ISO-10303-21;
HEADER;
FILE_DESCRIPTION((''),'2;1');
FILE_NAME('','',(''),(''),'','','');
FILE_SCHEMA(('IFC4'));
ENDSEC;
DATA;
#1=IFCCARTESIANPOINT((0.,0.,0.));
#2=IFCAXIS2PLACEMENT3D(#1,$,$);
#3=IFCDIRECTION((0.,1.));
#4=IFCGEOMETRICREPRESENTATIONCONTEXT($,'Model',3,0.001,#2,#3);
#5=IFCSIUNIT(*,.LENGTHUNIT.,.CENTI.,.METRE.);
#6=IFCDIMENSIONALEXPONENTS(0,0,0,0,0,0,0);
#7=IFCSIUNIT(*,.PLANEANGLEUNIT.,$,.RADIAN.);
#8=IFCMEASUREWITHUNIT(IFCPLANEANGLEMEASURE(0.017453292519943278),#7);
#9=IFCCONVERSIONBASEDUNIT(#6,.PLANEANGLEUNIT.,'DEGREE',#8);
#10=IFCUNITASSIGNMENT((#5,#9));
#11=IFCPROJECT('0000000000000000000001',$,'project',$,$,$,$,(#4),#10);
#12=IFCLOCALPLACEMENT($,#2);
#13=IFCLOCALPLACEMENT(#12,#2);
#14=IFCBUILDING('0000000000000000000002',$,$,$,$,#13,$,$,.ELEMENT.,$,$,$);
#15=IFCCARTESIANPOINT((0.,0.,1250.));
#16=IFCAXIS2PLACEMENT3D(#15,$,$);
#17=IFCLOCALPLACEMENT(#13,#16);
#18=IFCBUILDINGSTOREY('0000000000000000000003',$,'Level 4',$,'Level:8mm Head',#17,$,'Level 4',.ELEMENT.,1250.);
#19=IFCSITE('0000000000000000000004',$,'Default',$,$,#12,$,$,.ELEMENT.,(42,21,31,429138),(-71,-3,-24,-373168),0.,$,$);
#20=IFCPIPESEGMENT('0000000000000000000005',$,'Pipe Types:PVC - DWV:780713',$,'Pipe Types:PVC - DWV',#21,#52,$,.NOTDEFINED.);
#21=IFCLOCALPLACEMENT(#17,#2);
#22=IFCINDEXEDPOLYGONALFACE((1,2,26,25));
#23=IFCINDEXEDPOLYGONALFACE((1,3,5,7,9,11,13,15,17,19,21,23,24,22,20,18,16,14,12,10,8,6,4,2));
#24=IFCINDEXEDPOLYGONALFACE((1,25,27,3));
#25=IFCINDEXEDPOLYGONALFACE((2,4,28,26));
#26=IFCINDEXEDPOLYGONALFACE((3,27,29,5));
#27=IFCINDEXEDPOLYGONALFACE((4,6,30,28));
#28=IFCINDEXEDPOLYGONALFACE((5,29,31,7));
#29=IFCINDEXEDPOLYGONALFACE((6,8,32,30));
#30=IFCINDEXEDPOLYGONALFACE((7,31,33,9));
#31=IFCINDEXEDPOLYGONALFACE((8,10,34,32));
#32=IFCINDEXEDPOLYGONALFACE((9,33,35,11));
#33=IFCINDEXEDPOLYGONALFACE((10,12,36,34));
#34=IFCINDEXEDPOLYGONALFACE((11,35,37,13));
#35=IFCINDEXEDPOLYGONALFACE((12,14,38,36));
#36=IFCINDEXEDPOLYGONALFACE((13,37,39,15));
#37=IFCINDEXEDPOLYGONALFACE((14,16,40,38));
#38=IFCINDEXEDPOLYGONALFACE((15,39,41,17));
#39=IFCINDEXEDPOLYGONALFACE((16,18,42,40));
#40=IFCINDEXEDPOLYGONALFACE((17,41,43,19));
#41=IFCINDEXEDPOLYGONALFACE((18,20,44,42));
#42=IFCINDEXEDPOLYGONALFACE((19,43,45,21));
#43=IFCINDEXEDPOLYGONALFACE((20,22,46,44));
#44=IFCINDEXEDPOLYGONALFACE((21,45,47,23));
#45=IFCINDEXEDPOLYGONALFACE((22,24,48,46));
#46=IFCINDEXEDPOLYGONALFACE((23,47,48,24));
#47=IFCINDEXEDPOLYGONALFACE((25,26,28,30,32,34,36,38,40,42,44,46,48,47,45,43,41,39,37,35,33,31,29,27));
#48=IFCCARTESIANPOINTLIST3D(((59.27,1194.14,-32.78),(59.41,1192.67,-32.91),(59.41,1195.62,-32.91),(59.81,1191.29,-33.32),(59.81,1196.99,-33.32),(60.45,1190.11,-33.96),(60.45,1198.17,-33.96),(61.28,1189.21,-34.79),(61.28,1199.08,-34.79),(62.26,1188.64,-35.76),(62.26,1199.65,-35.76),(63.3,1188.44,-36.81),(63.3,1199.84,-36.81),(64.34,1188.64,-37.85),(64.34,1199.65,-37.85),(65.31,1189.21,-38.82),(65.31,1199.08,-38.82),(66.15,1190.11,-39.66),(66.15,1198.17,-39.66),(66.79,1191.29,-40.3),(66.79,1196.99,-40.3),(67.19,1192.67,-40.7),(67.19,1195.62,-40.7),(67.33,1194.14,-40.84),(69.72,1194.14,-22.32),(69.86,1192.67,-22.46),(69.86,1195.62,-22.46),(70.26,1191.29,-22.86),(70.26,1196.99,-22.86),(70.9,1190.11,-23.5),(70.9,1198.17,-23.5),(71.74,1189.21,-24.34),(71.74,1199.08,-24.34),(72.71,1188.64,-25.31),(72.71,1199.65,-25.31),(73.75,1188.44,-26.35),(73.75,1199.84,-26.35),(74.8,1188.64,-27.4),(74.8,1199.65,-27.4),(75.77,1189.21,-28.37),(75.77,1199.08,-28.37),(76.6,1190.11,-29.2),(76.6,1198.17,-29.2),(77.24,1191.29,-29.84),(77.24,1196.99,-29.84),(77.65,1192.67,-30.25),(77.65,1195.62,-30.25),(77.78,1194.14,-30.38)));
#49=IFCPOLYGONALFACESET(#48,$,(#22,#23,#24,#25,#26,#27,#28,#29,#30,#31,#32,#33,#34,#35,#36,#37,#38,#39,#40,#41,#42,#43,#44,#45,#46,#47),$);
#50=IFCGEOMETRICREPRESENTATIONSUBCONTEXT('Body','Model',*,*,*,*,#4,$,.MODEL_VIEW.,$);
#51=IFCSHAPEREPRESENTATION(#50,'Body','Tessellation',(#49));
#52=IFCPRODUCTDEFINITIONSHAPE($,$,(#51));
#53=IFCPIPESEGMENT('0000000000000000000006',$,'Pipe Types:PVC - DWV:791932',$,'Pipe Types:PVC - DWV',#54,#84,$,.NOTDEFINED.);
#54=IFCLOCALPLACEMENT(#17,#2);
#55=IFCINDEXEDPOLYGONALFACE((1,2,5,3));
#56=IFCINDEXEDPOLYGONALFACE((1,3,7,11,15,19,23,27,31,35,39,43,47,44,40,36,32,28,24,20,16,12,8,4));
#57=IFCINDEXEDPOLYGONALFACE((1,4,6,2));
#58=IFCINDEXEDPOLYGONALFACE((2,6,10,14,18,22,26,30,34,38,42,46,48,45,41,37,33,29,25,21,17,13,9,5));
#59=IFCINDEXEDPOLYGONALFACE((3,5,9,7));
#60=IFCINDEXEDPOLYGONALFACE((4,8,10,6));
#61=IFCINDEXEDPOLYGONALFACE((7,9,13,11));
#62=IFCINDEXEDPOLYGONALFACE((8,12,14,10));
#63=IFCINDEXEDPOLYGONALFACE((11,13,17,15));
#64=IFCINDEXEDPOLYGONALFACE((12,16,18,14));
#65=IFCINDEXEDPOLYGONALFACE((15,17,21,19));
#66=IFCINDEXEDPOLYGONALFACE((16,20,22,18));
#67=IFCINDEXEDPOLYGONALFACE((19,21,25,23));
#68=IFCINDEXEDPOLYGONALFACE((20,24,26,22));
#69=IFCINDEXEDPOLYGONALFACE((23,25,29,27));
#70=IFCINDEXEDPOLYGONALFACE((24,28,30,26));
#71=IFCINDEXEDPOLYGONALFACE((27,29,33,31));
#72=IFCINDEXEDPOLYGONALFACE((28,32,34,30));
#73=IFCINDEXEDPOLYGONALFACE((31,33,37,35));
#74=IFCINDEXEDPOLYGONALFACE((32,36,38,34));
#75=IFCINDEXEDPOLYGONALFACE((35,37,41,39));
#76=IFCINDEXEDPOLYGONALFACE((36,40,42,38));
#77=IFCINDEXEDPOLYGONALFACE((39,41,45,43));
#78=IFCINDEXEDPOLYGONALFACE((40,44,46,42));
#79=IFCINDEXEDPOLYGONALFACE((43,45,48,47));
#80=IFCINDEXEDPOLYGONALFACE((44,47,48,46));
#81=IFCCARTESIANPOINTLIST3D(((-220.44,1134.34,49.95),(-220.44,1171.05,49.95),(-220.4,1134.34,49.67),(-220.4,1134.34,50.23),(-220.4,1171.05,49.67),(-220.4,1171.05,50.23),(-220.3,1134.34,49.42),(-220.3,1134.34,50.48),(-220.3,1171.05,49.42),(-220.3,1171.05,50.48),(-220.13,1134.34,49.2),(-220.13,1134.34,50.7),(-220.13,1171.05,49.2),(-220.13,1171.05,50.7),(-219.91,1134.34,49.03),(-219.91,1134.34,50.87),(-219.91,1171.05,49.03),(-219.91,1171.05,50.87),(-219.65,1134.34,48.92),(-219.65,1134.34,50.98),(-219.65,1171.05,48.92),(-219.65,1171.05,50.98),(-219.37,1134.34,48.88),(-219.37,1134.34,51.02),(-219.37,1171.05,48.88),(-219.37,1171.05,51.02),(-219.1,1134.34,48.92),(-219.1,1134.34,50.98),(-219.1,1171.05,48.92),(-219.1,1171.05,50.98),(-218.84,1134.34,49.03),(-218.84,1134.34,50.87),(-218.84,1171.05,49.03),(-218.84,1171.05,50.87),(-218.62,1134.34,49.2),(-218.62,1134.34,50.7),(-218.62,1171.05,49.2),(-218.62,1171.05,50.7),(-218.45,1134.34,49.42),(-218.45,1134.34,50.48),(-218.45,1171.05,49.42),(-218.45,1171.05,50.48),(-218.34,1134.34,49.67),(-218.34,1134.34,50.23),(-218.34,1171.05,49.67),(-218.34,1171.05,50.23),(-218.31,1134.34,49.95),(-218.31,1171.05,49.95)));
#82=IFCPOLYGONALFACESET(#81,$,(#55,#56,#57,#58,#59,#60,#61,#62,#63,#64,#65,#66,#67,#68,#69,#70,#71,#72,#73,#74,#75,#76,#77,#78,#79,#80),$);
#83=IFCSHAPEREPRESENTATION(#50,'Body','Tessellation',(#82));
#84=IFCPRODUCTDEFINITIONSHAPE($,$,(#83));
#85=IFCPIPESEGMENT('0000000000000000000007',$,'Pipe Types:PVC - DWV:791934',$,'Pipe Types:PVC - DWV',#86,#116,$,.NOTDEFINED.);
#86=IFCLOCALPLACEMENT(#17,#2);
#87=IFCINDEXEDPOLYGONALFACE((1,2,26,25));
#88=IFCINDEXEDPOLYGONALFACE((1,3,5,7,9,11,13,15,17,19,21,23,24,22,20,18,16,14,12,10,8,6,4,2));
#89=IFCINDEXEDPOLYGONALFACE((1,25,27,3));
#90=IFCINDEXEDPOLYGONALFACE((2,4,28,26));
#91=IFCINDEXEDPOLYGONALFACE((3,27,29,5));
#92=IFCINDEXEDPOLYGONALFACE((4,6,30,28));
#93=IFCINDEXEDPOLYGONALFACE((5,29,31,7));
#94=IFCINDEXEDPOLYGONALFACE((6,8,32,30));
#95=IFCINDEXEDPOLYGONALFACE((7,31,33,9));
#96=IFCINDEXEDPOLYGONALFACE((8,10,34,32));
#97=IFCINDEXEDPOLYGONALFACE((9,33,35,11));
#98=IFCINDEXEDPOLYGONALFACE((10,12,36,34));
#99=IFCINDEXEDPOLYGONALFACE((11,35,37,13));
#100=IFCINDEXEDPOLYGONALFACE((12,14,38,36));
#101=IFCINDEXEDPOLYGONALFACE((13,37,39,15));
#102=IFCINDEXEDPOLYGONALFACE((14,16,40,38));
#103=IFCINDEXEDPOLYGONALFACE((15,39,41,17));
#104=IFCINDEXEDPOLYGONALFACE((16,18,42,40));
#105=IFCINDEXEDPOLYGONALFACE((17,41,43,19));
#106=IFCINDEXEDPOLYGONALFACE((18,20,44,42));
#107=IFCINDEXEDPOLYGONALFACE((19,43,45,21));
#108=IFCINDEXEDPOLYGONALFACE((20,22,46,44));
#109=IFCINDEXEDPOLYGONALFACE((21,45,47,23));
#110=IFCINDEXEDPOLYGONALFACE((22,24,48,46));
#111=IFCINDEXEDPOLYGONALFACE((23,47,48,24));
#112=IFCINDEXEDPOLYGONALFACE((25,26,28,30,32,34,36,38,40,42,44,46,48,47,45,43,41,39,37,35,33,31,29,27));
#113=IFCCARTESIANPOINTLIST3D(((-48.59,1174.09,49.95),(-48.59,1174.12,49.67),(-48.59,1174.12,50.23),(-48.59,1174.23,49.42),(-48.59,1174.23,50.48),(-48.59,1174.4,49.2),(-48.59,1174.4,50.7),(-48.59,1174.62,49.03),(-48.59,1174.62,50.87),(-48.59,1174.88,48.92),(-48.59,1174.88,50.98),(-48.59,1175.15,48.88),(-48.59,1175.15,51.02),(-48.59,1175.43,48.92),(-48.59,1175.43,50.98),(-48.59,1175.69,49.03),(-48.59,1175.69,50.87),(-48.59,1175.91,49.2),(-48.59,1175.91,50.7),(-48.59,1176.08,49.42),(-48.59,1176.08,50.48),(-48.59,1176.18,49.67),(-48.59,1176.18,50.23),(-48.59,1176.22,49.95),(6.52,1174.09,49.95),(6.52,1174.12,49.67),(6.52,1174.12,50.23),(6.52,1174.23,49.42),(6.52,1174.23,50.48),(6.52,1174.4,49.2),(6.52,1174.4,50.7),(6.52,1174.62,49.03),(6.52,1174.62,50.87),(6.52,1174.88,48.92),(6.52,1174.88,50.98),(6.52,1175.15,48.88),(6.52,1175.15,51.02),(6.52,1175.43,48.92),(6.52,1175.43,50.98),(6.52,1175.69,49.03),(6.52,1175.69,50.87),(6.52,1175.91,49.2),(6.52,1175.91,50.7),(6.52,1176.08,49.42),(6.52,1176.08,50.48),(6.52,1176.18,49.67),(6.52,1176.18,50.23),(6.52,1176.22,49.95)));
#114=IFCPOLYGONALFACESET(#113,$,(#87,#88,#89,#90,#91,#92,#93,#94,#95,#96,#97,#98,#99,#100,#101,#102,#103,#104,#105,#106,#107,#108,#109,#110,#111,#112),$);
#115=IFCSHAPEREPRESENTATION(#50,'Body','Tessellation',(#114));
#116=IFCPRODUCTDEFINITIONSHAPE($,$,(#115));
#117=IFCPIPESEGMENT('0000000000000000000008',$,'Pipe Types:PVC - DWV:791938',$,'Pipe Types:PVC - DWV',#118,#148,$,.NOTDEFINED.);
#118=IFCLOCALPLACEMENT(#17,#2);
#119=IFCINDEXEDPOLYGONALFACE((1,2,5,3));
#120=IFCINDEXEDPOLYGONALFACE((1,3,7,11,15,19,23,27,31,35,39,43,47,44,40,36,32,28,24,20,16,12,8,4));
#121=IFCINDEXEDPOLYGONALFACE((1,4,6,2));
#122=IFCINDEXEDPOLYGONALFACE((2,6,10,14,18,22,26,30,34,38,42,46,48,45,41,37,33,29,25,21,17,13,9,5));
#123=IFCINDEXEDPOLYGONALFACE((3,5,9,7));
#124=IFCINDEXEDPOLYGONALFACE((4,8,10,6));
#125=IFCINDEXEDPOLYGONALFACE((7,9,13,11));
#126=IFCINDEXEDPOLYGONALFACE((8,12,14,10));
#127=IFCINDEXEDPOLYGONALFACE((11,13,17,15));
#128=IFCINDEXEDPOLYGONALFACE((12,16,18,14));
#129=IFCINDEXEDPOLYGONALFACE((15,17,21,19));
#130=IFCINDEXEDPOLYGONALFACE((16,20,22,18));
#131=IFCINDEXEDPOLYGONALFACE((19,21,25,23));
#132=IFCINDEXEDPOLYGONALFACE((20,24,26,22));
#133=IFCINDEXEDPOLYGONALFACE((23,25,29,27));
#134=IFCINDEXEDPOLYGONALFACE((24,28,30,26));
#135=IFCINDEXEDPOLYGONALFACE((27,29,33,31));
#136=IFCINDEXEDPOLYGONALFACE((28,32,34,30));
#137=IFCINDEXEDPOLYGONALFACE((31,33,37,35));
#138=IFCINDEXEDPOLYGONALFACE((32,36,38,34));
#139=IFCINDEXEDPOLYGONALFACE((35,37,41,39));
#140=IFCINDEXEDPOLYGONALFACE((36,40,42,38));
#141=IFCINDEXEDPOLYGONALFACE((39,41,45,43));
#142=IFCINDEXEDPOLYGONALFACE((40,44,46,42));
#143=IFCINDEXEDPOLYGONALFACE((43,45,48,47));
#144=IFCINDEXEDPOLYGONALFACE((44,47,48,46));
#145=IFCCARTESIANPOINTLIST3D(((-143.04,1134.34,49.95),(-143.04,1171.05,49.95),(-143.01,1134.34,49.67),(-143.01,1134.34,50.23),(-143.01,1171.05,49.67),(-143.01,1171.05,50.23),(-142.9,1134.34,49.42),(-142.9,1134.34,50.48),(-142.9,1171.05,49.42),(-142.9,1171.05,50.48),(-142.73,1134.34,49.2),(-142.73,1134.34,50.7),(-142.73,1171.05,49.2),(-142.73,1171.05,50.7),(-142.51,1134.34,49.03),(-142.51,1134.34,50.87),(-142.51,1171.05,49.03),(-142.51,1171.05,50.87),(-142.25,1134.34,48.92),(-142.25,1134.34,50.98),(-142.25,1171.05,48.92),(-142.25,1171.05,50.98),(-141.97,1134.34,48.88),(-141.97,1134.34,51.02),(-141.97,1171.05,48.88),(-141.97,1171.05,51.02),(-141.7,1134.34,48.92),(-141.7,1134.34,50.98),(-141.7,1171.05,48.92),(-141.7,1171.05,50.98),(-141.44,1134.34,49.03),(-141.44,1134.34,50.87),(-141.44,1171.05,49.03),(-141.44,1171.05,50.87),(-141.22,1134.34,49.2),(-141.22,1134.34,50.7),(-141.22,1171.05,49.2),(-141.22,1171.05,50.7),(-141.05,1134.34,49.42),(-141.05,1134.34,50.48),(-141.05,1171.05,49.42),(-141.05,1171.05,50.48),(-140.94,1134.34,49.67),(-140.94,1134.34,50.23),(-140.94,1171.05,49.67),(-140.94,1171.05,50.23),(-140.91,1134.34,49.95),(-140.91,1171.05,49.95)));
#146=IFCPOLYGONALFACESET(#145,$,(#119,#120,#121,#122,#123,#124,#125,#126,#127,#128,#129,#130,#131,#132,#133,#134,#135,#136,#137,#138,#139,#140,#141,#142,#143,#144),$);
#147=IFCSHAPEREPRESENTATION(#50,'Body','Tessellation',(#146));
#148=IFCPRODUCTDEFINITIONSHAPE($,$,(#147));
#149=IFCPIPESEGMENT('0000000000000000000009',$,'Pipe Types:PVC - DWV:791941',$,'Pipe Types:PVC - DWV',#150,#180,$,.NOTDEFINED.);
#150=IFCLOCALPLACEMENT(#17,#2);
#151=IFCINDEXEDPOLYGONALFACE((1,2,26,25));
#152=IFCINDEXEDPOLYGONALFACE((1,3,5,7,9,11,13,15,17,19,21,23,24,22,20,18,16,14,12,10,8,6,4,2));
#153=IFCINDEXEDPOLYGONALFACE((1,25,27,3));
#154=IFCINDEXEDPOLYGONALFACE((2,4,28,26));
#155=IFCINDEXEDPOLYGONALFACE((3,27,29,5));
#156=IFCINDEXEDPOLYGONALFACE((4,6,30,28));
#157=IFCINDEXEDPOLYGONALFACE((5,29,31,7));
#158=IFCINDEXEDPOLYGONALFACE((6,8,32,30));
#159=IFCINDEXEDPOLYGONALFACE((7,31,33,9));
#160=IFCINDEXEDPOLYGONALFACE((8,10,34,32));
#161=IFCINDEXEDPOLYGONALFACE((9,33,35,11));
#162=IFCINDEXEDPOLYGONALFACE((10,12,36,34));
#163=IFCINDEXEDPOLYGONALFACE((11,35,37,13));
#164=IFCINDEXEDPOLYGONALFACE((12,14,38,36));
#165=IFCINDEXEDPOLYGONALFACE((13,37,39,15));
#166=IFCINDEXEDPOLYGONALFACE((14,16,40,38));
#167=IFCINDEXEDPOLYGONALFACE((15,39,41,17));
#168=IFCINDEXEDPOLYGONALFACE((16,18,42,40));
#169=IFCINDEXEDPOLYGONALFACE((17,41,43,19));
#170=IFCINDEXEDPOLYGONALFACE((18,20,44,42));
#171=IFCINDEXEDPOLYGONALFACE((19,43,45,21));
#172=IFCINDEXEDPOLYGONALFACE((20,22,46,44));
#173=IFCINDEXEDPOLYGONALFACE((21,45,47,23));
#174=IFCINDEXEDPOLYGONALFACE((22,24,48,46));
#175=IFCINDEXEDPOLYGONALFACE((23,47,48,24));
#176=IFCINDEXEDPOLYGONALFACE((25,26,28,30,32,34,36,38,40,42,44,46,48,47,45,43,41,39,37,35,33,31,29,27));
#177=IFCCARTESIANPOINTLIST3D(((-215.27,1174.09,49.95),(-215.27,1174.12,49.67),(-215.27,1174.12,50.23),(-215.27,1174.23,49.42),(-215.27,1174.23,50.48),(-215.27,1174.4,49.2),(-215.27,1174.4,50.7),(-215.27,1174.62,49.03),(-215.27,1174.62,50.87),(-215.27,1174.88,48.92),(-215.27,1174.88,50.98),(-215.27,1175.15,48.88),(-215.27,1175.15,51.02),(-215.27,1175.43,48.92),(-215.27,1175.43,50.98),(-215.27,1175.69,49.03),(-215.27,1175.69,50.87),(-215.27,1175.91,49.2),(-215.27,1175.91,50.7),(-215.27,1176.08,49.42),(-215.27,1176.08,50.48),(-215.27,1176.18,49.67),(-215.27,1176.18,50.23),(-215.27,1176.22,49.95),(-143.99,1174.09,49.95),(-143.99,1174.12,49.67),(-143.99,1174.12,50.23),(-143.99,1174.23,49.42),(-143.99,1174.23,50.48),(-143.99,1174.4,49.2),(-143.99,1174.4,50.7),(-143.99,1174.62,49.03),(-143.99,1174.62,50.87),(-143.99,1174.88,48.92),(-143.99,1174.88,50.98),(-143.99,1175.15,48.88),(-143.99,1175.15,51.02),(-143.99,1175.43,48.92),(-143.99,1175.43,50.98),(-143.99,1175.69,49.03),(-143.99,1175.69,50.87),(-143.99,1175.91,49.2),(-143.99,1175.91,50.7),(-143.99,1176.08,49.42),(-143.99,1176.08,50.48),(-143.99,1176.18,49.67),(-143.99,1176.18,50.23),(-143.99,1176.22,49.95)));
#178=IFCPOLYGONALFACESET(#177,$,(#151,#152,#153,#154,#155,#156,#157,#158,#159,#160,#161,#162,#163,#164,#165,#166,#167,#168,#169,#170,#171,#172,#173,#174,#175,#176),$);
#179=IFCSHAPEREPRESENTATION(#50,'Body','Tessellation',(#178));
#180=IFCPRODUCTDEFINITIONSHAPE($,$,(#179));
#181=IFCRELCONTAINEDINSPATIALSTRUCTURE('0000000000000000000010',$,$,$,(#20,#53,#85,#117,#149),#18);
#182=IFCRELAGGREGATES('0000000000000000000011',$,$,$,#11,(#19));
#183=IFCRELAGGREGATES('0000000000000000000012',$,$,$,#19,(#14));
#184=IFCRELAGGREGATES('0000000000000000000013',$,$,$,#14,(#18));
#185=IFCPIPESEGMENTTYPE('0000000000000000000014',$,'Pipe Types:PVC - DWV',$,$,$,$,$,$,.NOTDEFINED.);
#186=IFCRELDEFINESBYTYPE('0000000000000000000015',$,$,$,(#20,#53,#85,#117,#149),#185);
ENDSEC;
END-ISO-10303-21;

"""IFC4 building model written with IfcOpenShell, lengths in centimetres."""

from ifc_helpers import new_model, entity, si_unit, converted_unit, direction, frame, origin, place, context, subcontext, project, spatial, arc, indexed_curve, outline, extrude, type_object, element, save


model = new_model("IFC4")

# Units and contexts
model_context = context("Model", 3, precision=0.001, world=origin(), true_north=direction((0.0, 1.0)))
body_context = subcontext(model_context, "Body", "Model", "MODEL_VIEW")
ifc_project = project(units=[si_unit("LENGTHUNIT", "METRE", prefix="CENTI"), converted_unit("PLANEANGLEUNIT", "DEGREE", entity("IfcPlaneAngleMeasure", 0.017453292519943278), si_unit("PLANEANGLEUNIT", "RADIAN"), dimensions=[0, 0, 0, 0, 0, 0, 0])], contexts=[model_context])

# Site, building, storey
site_placement = place(None, origin())
site = spatial("IfcSite", under=ifc_project, at=site_placement, Name="Default", CompositionType="ELEMENT", RefLatitude=(42, 21, 31, 429138), RefLongitude=(-71, -3, -24, -373168), RefElevation=0.0)
building_placement = place(site_placement, origin())
building = spatial("IfcBuilding", under=site, at=building_placement, CompositionType="ELEMENT")
storey_placement = place(building_placement, frame((0.0, 0.0, 1250.0)))
storey = spatial("IfcBuildingStorey", under=building, at=storey_placement, Name="Level 4", ObjectType="Level:8mm Head", LongName="Level 4", CompositionType="ELEMENT", Elevation=1250.0)

# Pipe segments
pipe_segment_type = type_object("IfcPipeSegmentType", Name="Pipe Types:PVC - DWV", PredefinedType="NOTDEFINED")
pipe_segment_1_placement = place(storey_placement, origin())
element("IfcPipeSegment", 1, at=pipe_segment_1_placement, inside=storey, type_object=pipe_segment_type, Name="Pipe Types:PVC - DWV:780713", ObjectType="Pipe Types:PVC - DWV", PredefinedType="NOTDEFINED", context=body_context, shape_type="SweptSolid", body=[
    extrude(outline(indexed_curve([(5.7, 0.0), (4.03, 4.03), (0.0, 5.7), (-4.03, 4.03), (-5.7, 0.0), (-4.03, -4.03), (0.0, -5.7), (4.03, -4.03)], segments=[arc(1, 2, 3), arc(3, 4, 5), arc(5, 6, 7), arc(7, 8, 1)], self_intersect=False)), frame((63.3, 1194.14, -36.81), z_axis=(0.707107, 0.0, 0.707107), x_axis=(0.0, -1.0, 0.0)), (0.0, 0.0, 1.0), 14.78),
])
pipe_segment_2_placement = place(storey_placement, origin())
element("IfcPipeSegment", 2, at=pipe_segment_2_placement, inside=storey, type_object=pipe_segment_type, Name="Pipe Types:PVC - DWV:791932", ObjectType="Pipe Types:PVC - DWV", PredefinedType="NOTDEFINED", context=body_context, shape_type="SweptSolid", body=[
    extrude(outline(indexed_curve([(1.07, 0.0), (0.75, 0.75), (0.0, 1.07), (-0.75, 0.75), (-1.07, 0.0), (-0.75, -0.75), (0.0, -1.07), (0.75, -0.75)], segments=[arc(1, 2, 3), arc(3, 4, 5), arc(5, 6, 7), arc(7, 8, 1)], self_intersect=False)), frame((-219.37, 1134.34, 49.95), z_axis=(0.0, 1.0, 0.0), x_axis=(1.0, 0.0, 0.0)), (0.0, 0.0, 1.0), 36.71),
])
pipe_segment_3_placement = place(storey_placement, origin())
element("IfcPipeSegment", 3, at=pipe_segment_3_placement, inside=storey, type_object=pipe_segment_type, Name="Pipe Types:PVC - DWV:791934", ObjectType="Pipe Types:PVC - DWV", PredefinedType="NOTDEFINED", context=body_context, shape_type="SweptSolid", body=[
    extrude(outline(indexed_curve([(1.07, 0.0), (0.75, 0.75), (0.0, 1.07), (-0.75, 0.75), (-1.07, 0.0), (-0.75, -0.75), (0.0, -1.07), (0.75, -0.75)], segments=[arc(1, 2, 3), arc(3, 4, 5), arc(5, 6, 7), arc(7, 8, 1)], self_intersect=False)), frame((-48.59, 1175.15, 49.95), z_axis=(1.0, 0.0, 0.0), x_axis=(0.0, -1.0, 0.0)), (0.0, 0.0, 1.0), 55.11),
])
pipe_segment_4_placement = place(storey_placement, origin())
element("IfcPipeSegment", 4, at=pipe_segment_4_placement, inside=storey, type_object=pipe_segment_type, Name="Pipe Types:PVC - DWV:791938", ObjectType="Pipe Types:PVC - DWV", PredefinedType="NOTDEFINED", context=body_context, shape_type="SweptSolid", body=[
    extrude(outline(indexed_curve([(1.07, 0.0), (0.75, 0.75), (0.0, 1.07), (-0.75, 0.75), (-1.07, 0.0), (-0.75, -0.75), (0.0, -1.07), (0.75, -0.75)], segments=[arc(1, 2, 3), arc(3, 4, 5), arc(5, 6, 7), arc(7, 8, 1)], self_intersect=False)), frame((-141.97, 1134.34, 49.95), z_axis=(0.0, 1.0, 0.0), x_axis=(-1.0, 0.0, 0.0)), (0.0, 0.0, 1.0), 36.71),
])
pipe_segment_5_placement = place(storey_placement, origin())
element("IfcPipeSegment", 5, at=pipe_segment_5_placement, inside=storey, type_object=pipe_segment_type, Name="Pipe Types:PVC - DWV:791941", ObjectType="Pipe Types:PVC - DWV", PredefinedType="NOTDEFINED", context=body_context, shape_type="SweptSolid", body=[
    extrude(outline(indexed_curve([(1.07, 0.0), (0.75, 0.75), (0.0, 1.07), (-0.75, 0.75), (-1.07, 0.0), (-0.75, -0.75), (0.0, -1.07), (0.75, -0.75)], segments=[arc(1, 2, 3), arc(3, 4, 5), arc(5, 6, 7), arc(7, 8, 1)], self_intersect=False)), frame((-215.27, 1175.15, 49.95), z_axis=(1.0, 0.0, 0.0), x_axis=(0.0, -1.0, 0.0)), (0.0, 0.0, 1.0), 71.29),
])

save(model, "model.ifc")
